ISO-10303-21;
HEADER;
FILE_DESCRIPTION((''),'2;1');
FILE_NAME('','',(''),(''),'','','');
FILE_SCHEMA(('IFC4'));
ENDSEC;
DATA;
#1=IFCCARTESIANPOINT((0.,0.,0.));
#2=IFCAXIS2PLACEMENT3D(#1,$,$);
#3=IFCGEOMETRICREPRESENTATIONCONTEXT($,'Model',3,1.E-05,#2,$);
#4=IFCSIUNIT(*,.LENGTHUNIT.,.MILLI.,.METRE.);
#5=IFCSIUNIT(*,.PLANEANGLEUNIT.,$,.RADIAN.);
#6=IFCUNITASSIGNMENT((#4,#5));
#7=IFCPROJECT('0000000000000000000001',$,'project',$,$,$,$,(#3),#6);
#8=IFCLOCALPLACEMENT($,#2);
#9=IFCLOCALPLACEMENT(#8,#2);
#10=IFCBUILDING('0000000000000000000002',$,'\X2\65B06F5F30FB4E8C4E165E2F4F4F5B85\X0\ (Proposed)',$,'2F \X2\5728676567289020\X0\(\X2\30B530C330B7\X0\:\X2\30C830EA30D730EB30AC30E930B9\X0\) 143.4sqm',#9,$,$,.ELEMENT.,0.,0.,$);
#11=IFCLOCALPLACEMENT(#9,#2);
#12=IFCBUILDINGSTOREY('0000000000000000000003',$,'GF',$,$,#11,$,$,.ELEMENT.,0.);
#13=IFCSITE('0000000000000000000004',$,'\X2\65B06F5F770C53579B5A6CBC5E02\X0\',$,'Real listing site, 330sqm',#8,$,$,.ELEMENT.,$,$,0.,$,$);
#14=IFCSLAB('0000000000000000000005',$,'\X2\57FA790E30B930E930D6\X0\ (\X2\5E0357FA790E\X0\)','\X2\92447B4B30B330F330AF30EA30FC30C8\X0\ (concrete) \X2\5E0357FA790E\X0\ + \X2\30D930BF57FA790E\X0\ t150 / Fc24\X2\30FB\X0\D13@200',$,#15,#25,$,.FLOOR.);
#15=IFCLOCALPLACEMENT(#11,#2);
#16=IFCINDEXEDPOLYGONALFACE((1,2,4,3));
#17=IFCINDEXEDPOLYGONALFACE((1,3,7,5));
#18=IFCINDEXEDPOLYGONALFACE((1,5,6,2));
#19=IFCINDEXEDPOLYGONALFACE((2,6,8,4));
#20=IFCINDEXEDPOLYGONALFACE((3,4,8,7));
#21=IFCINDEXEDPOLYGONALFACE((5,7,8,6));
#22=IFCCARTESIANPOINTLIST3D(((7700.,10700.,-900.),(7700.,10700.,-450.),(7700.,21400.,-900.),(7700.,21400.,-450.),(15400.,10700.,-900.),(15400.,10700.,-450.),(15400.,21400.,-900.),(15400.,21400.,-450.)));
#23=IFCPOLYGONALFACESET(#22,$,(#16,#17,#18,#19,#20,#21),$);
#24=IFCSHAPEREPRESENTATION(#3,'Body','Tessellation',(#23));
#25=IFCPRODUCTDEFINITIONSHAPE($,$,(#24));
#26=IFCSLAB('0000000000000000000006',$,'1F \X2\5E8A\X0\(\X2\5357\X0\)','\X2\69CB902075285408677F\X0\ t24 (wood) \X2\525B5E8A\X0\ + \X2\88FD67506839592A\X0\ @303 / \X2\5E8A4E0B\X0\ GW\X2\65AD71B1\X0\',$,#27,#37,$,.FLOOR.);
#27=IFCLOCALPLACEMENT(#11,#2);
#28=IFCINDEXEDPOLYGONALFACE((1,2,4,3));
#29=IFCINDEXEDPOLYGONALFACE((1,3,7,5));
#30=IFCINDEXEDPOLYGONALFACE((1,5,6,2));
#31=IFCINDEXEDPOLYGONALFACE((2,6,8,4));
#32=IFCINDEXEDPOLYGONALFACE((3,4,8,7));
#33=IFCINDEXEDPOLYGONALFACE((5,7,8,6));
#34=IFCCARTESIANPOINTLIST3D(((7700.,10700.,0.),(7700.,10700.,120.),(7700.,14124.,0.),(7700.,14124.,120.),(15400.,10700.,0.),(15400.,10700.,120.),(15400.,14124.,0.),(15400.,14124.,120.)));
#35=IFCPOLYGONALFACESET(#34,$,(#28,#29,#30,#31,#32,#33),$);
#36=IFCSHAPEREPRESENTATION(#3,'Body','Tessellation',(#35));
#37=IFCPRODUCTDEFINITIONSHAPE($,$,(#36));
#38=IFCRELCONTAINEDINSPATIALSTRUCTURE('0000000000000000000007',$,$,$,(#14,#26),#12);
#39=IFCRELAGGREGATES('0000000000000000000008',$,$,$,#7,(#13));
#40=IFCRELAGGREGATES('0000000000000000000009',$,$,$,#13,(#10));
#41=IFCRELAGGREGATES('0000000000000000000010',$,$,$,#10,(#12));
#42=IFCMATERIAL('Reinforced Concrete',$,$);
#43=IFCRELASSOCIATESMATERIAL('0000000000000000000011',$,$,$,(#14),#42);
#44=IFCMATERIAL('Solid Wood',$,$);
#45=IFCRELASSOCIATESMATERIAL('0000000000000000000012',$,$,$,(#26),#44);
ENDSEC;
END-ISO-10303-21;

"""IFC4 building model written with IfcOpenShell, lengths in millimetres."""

from ifc_helpers import new_model, si_unit, frame, frame_2d, origin, place, context, project, spatial, rectangle, extrude, material, element, save


model = new_model("IFC4")

# Units and contexts
model_context = context("Model", 3, precision=1e-05, world=origin())
ifc_project = project(units=[si_unit("LENGTHUNIT", "METRE", prefix="MILLI"), si_unit("PLANEANGLEUNIT", "RADIAN")], contexts=[model_context])

# Site, building, storey
site_placement = place(None, origin())
site = spatial("IfcSite", under=ifc_project, at=site_placement, Name="新潟県南魚沼市", ObjectType="Real listing site, 330sqm", CompositionType="ELEMENT", RefElevation=0.0)
building_placement = place(site_placement, origin())
building = spatial("IfcBuilding", under=site, at=building_placement, Name="新潟・二世帯住宅 (Proposed)", ObjectType="2F 在来木造(サッシ:トリプルガラス) 143.4sqm", CompositionType="ELEMENT", ElevationOfRefHeight=0.0, ElevationOfTerrain=0.0)
storey_placement = place(building_placement, origin())
storey = spatial("IfcBuildingStorey", under=building, at=storey_placement, Name="GF", CompositionType="ELEMENT", Elevation=0.0)

# Shared definitions
ifc_material_1 = material(Name="Solid Wood")

# Slabs
ifc_material_2 = material(Name="Reinforced Concrete")
slab_1_placement = place(storey_placement, frame((3850.0, 5350.0, -450.0)))
element("IfcSlab", 1, at=slab_1_placement, inside=storey, material=ifc_material_2, Name="基礎スラブ (布基礎)", Description="鉄筋コンクリート (concrete) 布基礎 + ベタ基礎 t150 / Fc24・D13@200", PredefinedType="FLOOR", context=model_context, shape_type="SweptSolid", body=[
    extrude(rectangle(XDim=7700.0, YDim=10700.0, at=frame_2d((3850.0, 5350.0))), frame((3850.0, 5350.0, -450.0)), (0.0, 0.0, 1.0), 450.0),
])
slab_2_placement = place(storey_placement, frame((3850.0, 5350.0, 0.0)))
element("IfcSlab", 2, at=slab_2_placement, inside=storey, material=ifc_material_1, Name="1F 床(南)", Description="構造用合板 t24 (wood) 剛床 + 製材根太 @303 / 床下 GW断熱", PredefinedType="FLOOR", context=model_context, shape_type="SweptSolid", body=[
    extrude(rectangle(XDim=7700.0, YDim=3424.0, at=frame_2d((3850.0, 1712.0))), frame((3850.0, 5350.0, 0.0)), (0.0, 0.0, 1.0), 120.0),
])

save(model, "model.ifc")
